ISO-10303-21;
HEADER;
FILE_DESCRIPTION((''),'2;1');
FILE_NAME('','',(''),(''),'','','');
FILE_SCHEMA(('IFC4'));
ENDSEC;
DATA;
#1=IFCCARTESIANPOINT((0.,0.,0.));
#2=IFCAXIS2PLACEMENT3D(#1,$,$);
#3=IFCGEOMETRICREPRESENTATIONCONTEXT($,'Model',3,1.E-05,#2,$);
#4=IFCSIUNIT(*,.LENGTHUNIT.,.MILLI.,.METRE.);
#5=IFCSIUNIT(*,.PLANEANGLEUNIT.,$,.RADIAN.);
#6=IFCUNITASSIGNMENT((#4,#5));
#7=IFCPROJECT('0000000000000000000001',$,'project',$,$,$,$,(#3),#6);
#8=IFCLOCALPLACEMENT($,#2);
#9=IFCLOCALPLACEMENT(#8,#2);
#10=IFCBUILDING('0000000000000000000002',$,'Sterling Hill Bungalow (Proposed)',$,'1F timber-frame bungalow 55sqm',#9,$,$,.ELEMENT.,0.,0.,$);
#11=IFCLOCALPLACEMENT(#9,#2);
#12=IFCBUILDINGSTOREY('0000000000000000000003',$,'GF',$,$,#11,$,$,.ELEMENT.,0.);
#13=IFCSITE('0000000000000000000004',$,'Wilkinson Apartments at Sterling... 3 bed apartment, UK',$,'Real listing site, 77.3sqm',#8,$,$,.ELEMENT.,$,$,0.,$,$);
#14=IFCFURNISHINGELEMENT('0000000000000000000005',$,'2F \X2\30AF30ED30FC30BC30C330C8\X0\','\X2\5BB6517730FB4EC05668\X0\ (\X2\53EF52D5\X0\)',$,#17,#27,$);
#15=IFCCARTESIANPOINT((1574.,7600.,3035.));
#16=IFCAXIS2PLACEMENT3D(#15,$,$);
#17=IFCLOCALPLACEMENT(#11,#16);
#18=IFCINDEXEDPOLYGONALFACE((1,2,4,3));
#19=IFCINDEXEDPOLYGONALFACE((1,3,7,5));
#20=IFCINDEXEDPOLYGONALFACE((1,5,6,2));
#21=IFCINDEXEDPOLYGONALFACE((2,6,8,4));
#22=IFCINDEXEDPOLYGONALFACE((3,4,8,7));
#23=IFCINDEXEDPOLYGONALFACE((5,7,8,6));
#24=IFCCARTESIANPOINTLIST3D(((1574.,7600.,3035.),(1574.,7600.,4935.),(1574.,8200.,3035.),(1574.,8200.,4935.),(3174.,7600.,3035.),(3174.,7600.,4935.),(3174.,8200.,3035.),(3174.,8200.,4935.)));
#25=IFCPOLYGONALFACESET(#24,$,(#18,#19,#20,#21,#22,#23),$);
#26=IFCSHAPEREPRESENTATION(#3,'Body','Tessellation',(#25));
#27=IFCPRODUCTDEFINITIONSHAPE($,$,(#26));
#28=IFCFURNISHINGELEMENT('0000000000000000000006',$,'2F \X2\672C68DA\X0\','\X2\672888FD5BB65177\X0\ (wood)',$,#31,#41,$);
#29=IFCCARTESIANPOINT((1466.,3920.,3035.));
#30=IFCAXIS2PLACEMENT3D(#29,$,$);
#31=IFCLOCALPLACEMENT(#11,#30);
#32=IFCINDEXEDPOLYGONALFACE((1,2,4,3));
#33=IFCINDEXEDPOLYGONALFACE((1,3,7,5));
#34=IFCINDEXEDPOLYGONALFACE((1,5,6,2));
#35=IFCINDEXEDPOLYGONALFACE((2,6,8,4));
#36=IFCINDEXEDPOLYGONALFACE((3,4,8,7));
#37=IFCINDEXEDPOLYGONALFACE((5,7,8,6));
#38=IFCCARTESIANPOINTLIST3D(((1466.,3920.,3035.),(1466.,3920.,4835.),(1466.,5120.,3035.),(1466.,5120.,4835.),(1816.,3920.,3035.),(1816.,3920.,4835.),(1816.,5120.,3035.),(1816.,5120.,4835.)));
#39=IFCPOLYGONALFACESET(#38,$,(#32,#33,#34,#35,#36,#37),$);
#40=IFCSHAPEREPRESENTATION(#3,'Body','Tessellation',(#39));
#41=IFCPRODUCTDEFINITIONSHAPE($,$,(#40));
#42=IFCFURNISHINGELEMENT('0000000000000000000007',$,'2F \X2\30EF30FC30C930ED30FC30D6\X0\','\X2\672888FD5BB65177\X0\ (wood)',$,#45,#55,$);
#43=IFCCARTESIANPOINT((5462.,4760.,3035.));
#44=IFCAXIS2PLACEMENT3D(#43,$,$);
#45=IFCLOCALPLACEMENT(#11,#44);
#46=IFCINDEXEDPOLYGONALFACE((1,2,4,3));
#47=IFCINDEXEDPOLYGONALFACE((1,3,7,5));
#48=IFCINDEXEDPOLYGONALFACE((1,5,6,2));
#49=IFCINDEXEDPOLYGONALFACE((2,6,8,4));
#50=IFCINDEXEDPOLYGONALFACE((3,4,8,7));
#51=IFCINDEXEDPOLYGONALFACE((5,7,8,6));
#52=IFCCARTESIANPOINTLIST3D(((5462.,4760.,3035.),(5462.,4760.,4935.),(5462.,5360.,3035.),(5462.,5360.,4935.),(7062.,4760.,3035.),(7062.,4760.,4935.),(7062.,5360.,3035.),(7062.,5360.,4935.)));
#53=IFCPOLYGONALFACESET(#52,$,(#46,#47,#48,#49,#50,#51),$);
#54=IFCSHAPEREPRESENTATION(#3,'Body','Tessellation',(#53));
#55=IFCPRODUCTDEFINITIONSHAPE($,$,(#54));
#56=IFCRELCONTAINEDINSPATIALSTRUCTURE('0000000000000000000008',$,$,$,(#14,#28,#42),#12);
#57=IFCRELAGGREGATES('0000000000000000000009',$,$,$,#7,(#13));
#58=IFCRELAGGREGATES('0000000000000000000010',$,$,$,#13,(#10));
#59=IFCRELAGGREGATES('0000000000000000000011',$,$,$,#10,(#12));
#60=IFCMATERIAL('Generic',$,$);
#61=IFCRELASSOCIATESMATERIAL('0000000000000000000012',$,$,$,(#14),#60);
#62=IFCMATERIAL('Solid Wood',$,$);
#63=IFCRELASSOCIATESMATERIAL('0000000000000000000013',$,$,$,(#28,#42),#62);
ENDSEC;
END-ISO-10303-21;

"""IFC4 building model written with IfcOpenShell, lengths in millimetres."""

from ifc_helpers import new_model, si_unit, frame, frame_2d, origin, place, context, project, spatial, rectangle, extrude, material, element, save


model = new_model("IFC4")

# Units and contexts
model_context = context("Model", 3, precision=1e-05, world=origin())
ifc_project = project(units=[si_unit("LENGTHUNIT", "METRE", prefix="MILLI"), si_unit("PLANEANGLEUNIT", "RADIAN")], contexts=[model_context])

# Site, building, storey
site_placement = place(None, origin())
site = spatial("IfcSite", under=ifc_project, at=site_placement, Name="Wilkinson Apartments at Sterling... 3 bed apartment, UK", ObjectType="Real listing site, 77.3sqm", CompositionType="ELEMENT", RefElevation=0.0)
building_placement = place(site_placement, origin())
building = spatial("IfcBuilding", under=site, at=building_placement, Name="Sterling Hill Bungalow (Proposed)", ObjectType="1F timber-frame bungalow 55sqm", CompositionType="ELEMENT", ElevationOfRefHeight=0.0, ElevationOfTerrain=0.0)
storey_placement = place(building_placement, origin())
storey = spatial("IfcBuildingStorey", under=building, at=storey_placement, Name="GF", CompositionType="ELEMENT", Elevation=0.0)

# Shared definitions
ifc_material_1 = material(Name="Solid Wood")

# Shared definitions
ifc_material_2 = material(Name="Generic")

# Furnishing elements
furnishing_1_placement = place(storey_placement, frame((1574.0, 7600.0, 3035.0)))
element("IfcFurnishingElement", 1, at=furnishing_1_placement, inside=storey, material=ifc_material_2, Name="2F クローゼット", Description="家具・什器 (可動)", context=model_context, shape_type="SweptSolid", body=[
    extrude(rectangle(XDim=1600.0, YDim=600.0, at=frame_2d((800.0, 300.0))), frame((1574.0, 7600.0, 3035.0)), (0.0, 0.0, 1.0), 1900.0),
])
furnishing_2_placement = place(storey_placement, frame((1466.0, 3920.0, 3035.0)))
element("IfcFurnishingElement", 2, at=furnishing_2_placement, inside=storey, material=ifc_material_1, Name="2F 本棚", Description="木製家具 (wood)", context=model_context, shape_type="SweptSolid", body=[
    extrude(rectangle(XDim=350.0, YDim=1200.0, at=frame_2d((175.0, 600.0))), frame((1466.0, 3920.0, 3035.0)), (0.0, 0.0, 1.0), 1800.0),
])
furnishing_3_placement = place(storey_placement, frame((5462.0, 4760.0, 3035.0)))
element("IfcFurnishingElement", 3, at=furnishing_3_placement, inside=storey, material=ifc_material_1, Name="2F ワードローブ", Description="木製家具 (wood)", context=model_context, shape_type="SweptSolid", body=[
    extrude(rectangle(XDim=1600.0, YDim=600.0, at=frame_2d((800.0, 300.0))), frame((5462.0, 4760.0, 3035.0)), (0.0, 0.0, 1.0), 1900.0),
])

save(model, "model.ifc")
